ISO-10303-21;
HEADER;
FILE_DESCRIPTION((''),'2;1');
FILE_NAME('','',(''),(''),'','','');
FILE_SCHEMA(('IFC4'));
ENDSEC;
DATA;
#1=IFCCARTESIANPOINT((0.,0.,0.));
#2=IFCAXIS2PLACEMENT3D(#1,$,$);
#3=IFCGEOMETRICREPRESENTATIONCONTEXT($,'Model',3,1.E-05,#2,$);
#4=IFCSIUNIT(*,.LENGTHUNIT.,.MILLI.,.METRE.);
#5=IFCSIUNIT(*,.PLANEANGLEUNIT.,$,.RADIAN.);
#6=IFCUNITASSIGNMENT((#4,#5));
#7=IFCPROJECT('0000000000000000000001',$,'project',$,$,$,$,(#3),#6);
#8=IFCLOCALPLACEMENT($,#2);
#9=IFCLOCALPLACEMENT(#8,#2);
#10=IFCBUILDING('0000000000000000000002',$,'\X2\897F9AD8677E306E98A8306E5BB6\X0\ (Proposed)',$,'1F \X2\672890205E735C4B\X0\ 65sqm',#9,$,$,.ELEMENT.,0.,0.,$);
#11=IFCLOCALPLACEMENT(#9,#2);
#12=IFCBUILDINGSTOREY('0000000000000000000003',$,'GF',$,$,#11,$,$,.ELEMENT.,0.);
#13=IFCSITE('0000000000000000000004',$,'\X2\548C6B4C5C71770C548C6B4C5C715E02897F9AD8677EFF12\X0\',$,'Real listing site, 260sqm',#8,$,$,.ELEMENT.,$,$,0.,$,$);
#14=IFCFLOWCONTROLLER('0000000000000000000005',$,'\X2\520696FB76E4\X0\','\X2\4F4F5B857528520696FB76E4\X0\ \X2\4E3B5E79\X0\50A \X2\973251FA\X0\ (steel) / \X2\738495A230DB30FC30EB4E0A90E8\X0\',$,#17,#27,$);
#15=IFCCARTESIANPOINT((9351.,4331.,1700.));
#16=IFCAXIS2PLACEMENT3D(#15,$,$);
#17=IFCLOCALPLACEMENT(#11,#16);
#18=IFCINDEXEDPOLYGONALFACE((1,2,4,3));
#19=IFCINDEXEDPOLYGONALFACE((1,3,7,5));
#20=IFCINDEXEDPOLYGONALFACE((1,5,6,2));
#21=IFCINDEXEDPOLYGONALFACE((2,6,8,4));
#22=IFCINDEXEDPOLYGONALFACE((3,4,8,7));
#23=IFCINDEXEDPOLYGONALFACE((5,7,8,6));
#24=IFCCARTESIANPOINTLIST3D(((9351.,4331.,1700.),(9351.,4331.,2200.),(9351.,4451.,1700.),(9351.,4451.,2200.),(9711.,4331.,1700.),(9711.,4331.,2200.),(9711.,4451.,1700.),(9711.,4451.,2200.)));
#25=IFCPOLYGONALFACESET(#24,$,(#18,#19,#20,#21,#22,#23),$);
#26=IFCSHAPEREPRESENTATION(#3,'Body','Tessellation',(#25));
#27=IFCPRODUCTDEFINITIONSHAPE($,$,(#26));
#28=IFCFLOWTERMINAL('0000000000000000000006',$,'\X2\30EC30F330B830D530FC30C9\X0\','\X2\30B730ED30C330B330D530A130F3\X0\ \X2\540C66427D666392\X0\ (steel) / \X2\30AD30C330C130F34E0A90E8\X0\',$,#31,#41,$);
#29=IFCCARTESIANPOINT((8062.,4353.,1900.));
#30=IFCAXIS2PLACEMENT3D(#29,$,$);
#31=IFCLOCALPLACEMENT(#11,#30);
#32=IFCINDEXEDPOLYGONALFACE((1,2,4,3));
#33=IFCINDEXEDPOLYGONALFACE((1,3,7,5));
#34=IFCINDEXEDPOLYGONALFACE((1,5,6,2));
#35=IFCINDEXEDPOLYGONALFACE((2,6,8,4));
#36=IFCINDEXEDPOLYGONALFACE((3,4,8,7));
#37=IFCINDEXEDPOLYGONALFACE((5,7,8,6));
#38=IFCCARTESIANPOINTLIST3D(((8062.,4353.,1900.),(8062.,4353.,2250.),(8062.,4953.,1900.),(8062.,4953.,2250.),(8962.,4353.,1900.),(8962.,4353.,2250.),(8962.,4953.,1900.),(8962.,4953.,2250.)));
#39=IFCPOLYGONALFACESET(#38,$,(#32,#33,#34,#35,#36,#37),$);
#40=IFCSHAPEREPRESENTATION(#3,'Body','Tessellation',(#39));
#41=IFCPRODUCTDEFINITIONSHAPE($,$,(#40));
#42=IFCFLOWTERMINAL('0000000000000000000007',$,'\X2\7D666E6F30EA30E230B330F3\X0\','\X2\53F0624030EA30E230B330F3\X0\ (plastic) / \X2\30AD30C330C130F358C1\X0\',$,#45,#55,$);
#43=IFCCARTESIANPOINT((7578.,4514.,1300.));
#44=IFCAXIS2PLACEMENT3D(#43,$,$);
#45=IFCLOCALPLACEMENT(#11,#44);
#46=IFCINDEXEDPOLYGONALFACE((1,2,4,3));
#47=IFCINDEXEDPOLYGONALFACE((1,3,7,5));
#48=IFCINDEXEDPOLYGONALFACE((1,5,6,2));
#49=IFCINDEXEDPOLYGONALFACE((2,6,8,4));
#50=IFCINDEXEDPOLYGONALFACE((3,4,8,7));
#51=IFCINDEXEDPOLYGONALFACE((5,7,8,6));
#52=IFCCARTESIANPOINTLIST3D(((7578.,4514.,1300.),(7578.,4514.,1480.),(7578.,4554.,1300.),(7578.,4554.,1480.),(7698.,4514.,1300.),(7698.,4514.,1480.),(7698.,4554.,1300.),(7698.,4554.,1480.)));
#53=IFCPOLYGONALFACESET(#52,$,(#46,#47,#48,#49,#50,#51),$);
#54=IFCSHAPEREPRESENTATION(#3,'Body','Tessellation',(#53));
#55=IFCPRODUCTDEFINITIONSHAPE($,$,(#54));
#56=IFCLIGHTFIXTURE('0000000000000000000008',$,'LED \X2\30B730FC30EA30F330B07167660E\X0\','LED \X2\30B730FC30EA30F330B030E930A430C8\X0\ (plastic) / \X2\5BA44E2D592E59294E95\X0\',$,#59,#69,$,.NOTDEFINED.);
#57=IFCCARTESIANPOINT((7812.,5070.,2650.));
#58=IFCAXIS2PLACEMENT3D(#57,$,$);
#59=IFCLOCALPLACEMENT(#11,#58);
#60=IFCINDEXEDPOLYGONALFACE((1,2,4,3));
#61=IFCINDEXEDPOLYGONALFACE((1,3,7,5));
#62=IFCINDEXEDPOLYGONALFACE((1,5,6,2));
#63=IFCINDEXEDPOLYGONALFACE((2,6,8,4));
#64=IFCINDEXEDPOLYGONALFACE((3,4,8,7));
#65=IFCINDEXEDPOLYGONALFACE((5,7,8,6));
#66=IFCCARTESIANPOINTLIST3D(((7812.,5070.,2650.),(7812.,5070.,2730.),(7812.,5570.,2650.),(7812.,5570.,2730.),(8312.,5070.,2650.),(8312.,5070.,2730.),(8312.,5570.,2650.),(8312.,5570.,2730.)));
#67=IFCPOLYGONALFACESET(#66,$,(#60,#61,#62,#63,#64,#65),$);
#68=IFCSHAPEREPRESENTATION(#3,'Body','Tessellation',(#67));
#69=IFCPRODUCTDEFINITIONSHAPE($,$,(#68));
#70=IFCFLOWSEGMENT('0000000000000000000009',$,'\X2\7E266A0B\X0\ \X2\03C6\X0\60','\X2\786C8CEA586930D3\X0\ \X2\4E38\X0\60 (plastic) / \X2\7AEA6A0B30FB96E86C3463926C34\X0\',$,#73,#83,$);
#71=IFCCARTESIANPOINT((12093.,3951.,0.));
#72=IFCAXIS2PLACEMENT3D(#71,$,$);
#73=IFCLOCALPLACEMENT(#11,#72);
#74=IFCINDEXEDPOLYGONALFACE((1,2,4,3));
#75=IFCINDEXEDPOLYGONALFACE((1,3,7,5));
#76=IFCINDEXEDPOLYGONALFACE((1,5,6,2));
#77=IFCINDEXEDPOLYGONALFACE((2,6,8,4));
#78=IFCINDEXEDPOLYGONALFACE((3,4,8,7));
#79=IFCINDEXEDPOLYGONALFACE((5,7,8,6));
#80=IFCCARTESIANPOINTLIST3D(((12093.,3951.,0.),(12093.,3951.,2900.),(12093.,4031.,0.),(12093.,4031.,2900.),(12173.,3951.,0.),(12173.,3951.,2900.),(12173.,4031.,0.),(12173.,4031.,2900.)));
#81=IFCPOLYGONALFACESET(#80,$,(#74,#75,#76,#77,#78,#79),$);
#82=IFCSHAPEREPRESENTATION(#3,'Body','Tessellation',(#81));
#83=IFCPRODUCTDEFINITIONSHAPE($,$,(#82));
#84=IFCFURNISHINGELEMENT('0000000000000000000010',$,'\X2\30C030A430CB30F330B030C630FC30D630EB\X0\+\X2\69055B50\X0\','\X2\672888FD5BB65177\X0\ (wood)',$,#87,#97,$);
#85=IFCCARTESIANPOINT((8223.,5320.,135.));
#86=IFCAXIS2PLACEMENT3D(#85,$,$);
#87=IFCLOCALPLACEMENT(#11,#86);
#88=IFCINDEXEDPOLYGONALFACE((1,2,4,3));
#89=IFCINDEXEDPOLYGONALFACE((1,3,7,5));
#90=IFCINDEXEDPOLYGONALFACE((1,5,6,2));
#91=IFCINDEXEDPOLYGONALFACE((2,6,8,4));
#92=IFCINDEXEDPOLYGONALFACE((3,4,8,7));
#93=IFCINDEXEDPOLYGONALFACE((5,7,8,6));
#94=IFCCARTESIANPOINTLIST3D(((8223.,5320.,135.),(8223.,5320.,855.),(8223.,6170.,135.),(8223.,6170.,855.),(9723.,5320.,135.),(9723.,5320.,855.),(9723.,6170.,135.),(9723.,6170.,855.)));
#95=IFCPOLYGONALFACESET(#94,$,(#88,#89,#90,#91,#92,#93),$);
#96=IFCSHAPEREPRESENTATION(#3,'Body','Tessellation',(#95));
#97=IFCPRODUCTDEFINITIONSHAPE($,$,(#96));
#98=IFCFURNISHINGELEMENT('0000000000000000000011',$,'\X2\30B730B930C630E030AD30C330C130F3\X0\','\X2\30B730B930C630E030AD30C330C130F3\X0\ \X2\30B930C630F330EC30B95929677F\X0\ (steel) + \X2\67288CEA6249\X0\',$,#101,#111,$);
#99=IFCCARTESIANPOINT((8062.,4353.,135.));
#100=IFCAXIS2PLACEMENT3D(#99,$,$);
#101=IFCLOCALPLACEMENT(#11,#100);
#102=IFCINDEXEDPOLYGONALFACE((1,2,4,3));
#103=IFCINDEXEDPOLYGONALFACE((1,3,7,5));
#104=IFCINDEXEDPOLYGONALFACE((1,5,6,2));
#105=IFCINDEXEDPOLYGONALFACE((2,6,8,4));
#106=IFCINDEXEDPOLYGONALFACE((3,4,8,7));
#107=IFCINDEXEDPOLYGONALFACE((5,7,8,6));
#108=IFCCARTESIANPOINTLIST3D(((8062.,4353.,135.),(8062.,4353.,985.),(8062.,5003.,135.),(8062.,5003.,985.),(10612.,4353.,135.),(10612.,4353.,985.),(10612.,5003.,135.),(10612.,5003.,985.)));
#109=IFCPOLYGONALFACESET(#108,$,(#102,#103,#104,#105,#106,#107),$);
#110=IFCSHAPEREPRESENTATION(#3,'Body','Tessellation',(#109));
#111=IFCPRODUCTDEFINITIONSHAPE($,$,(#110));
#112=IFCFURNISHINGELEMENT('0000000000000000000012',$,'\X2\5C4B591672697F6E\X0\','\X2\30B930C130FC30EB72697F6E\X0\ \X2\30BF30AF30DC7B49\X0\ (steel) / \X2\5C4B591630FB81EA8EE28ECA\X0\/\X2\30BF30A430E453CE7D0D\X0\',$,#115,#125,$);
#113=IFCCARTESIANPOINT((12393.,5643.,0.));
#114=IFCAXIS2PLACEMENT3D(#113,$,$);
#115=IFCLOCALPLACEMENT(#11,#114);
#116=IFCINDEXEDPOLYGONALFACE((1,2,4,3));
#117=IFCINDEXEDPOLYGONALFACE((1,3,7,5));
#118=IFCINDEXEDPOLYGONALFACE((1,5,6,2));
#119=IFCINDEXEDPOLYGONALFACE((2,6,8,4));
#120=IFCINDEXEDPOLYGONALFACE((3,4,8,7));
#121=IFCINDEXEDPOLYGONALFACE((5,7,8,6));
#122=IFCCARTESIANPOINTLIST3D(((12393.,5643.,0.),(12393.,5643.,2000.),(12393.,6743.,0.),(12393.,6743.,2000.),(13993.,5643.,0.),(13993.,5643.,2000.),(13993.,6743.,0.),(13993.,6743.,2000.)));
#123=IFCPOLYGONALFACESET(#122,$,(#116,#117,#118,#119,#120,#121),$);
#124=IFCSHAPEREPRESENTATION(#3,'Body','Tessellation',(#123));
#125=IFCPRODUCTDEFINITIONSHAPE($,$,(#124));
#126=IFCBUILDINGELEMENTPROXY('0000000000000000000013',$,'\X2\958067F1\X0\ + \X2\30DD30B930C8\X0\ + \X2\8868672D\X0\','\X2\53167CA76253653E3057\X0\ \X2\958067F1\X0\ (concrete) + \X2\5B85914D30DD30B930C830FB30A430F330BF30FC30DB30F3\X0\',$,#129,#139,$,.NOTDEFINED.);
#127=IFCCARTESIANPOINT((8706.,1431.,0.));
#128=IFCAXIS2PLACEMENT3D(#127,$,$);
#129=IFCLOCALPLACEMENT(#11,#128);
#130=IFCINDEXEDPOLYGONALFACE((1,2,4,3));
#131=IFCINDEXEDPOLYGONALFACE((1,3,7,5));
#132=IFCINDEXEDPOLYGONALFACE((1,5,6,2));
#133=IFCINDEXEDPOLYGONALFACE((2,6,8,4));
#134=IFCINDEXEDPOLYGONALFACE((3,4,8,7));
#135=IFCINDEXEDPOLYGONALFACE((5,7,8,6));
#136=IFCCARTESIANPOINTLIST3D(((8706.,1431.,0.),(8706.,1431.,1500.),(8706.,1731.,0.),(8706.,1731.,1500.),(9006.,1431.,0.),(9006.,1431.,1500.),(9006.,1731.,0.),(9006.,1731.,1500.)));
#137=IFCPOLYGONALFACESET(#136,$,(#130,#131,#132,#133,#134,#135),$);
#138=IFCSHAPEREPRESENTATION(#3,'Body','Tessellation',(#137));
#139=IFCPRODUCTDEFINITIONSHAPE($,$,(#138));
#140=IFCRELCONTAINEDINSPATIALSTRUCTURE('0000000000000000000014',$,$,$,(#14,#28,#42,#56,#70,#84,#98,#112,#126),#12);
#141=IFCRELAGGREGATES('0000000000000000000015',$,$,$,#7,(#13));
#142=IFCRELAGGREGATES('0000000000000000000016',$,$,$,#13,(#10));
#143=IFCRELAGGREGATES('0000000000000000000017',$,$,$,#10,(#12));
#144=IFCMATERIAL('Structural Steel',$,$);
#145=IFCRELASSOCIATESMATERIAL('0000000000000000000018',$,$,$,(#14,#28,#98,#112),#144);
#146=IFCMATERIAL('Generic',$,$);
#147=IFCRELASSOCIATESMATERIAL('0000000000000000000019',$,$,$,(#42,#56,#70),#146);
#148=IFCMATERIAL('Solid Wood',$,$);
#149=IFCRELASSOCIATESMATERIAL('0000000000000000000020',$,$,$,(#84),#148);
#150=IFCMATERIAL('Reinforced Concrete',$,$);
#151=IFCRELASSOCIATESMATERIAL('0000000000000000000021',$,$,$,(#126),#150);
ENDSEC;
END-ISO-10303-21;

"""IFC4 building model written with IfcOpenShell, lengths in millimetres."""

from ifc_helpers import new_model, si_unit, frame, frame_2d, origin, place, context, project, spatial, rectangle, extrude, material, element, save


model = new_model("IFC4")

# Units and contexts
model_context = context("Model", 3, precision=1e-05, world=origin())
ifc_project = project(units=[si_unit("LENGTHUNIT", "METRE", prefix="MILLI"), si_unit("PLANEANGLEUNIT", "RADIAN")], contexts=[model_context])

# Site, building, storey
site_placement = place(None, origin())
site = spatial("IfcSite", under=ifc_project, at=site_placement, Name="和歌山県和歌山市西高松２", ObjectType="Real listing site, 260sqm", CompositionType="ELEMENT", RefElevation=0.0)
building_placement = place(site_placement, origin())
building = spatial("IfcBuilding", under=site, at=building_placement, Name="西高松の風の家 (Proposed)", ObjectType="1F 木造平屋 65sqm", CompositionType="ELEMENT", ElevationOfRefHeight=0.0, ElevationOfTerrain=0.0)
storey_placement = place(building_placement, origin())
storey = spatial("IfcBuildingStorey", under=building, at=storey_placement, Name="GF", CompositionType="ELEMENT", Elevation=0.0)

# Shared definitions
ifc_material_1 = material(Name="Solid Wood")

# Shared definitions
ifc_material_2 = material(Name="Structural Steel")

# Shared definitions
ifc_material_3 = material(Name="Reinforced Concrete")

# Flow controller
flow_controller_placement = place(storey_placement, frame((9351.0, 4331.0, 1700.0)))
element("IfcFlowController", 1, at=flow_controller_placement, inside=storey, material=ifc_material_2, Name="分電盤", Description="住宅用分電盤 主幹50A 露出 (steel) / 玄関ホール上部", context=model_context, shape_type="SweptSolid", body=[
    extrude(rectangle(XDim=360.0, YDim=120.0, at=frame_2d((180.0, 60.0))), frame((9351.0, 4331.0, 1700.0)), (0.0, 0.0, 1.0), 500.0),
])

# Flow terminals
flow_terminal_1_placement = place(storey_placement, frame((8062.0, 4353.0, 1900.0)))
element("IfcFlowTerminal", 2, at=flow_terminal_1_placement, inside=storey, material=ifc_material_2, Name="レンジフード", Description="シロッコファン 同時給排 (steel) / キッチン上部", context=model_context, shape_type="SweptSolid", body=[
    extrude(rectangle(XDim=900.0, YDim=600.0, at=frame_2d((450.0, 300.0))), frame((8062.0, 4353.0, 1900.0)), (0.0, 0.0, 1.0), 350.0),
])
ifc_material_4 = material(Name="Generic")
flow_terminal_2_placement = place(storey_placement, frame((7578.0, 4514.0, 1300.0)))
element("IfcFlowTerminal", 3, at=flow_terminal_2_placement, inside=storey, material=ifc_material_4, Name="給湯リモコン", Description="台所リモコン (plastic) / キッチン壁", context=model_context, shape_type="SweptSolid", body=[
    extrude(rectangle(XDim=120.0, YDim=40.0, at=frame_2d((60.0, 20.0))), frame((7578.0, 4514.0, 1300.0)), (0.0, 0.0, 1.0), 180.0),
])

# Light fixture
light_fixture_placement = place(storey_placement, frame((7812.0, 5070.0, 2650.0)))
element("IfcLightFixture", 4, at=light_fixture_placement, inside=storey, material=ifc_material_4, Name="LED シーリング照明", Description="LED シーリングライト (plastic) / 室中央天井", PredefinedType="NOTDEFINED", context=model_context, shape_type="SweptSolid", body=[
    extrude(rectangle(XDim=500.0, YDim=500.0, at=frame_2d((250.0, 250.0))), frame((7812.0, 5070.0, 2650.0)), (0.0, 0.0, 1.0), 80.0),
])

# Flow segment
flow_segment_placement = place(storey_placement, frame((12093.0, 3951.0, 0.0)))
element("IfcFlowSegment", 5, at=flow_segment_placement, inside=storey, material=ifc_material_4, Name="縦樋 φ60", Description="硬質塩ビ 丸60 (plastic) / 竪樋・雨水排水", context=model_context, shape_type="SweptSolid", body=[
    extrude(rectangle(XDim=80.0, YDim=80.0, at=frame_2d((40.0, 40.0))), frame((12093.0, 3951.0, 0.0)), (0.0, 0.0, 1.0), 2900.0),
])

# Furnishing elements
furnishing_1_placement = place(storey_placement, frame((8223.0, 5320.0, 135.0)))
element("IfcFurnishingElement", 6, at=furnishing_1_placement, inside=storey, material=ifc_material_1, Name="ダイニングテーブル+椅子", Description="木製家具 (wood)", context=model_context, shape_type="SweptSolid", body=[
    extrude(rectangle(XDim=1500.0, YDim=850.0, at=frame_2d((750.0, 425.0))), frame((8223.0, 5320.0, 135.0)), (0.0, 0.0, 1.0), 720.0),
])
furnishing_2_placement = place(storey_placement, frame((8062.0, 4353.0, 135.0)))
element("IfcFurnishingElement", 7, at=furnishing_2_placement, inside=storey, material=ifc_material_2, Name="システムキッチン", Description="システムキッチン ステンレス天板 (steel) + 木質扉", context=model_context, shape_type="SweptSolid", body=[
    extrude(rectangle(XDim=2550.0, YDim=650.0, at=frame_2d((1275.0, 325.0))), frame((8062.0, 4353.0, 135.0)), (0.0, 0.0, 1.0), 850.0),
])
furnishing_3_placement = place(storey_placement, frame((12393.0, 5643.0, 0.0)))
element("IfcFurnishingElement", 8, at=furnishing_3_placement, inside=storey, material=ifc_material_2, Name="屋外物置", Description="スチール物置 タクボ等 (steel) / 屋外・自転車/タイヤ収納", context=model_context, shape_type="SweptSolid", body=[
    extrude(rectangle(XDim=1600.0, YDim=1100.0, at=frame_2d((800.0, 550.0))), frame((12393.0, 5643.0, 0.0)), (0.0, 0.0, 1.0), 2000.0),
])

# Building element proxy
proxy_placement = place(storey_placement, frame((8706.0, 1431.0, 0.0)))
element("IfcBuildingElementProxy", 9, at=proxy_placement, inside=storey, material=ifc_material_3, Name="門柱 + ポスト + 表札", Description="化粧打放し 門柱 (concrete) + 宅配ポスト・インターホン", PredefinedType="NOTDEFINED", context=model_context, shape_type="SweptSolid", body=[
    extrude(rectangle(XDim=300.0, YDim=300.0, at=frame_2d((150.0, 150.0))), frame((8706.0, 1431.0, 0.0)), (0.0, 0.0, 1.0), 1500.0),
])

save(model, "model.ifc")
